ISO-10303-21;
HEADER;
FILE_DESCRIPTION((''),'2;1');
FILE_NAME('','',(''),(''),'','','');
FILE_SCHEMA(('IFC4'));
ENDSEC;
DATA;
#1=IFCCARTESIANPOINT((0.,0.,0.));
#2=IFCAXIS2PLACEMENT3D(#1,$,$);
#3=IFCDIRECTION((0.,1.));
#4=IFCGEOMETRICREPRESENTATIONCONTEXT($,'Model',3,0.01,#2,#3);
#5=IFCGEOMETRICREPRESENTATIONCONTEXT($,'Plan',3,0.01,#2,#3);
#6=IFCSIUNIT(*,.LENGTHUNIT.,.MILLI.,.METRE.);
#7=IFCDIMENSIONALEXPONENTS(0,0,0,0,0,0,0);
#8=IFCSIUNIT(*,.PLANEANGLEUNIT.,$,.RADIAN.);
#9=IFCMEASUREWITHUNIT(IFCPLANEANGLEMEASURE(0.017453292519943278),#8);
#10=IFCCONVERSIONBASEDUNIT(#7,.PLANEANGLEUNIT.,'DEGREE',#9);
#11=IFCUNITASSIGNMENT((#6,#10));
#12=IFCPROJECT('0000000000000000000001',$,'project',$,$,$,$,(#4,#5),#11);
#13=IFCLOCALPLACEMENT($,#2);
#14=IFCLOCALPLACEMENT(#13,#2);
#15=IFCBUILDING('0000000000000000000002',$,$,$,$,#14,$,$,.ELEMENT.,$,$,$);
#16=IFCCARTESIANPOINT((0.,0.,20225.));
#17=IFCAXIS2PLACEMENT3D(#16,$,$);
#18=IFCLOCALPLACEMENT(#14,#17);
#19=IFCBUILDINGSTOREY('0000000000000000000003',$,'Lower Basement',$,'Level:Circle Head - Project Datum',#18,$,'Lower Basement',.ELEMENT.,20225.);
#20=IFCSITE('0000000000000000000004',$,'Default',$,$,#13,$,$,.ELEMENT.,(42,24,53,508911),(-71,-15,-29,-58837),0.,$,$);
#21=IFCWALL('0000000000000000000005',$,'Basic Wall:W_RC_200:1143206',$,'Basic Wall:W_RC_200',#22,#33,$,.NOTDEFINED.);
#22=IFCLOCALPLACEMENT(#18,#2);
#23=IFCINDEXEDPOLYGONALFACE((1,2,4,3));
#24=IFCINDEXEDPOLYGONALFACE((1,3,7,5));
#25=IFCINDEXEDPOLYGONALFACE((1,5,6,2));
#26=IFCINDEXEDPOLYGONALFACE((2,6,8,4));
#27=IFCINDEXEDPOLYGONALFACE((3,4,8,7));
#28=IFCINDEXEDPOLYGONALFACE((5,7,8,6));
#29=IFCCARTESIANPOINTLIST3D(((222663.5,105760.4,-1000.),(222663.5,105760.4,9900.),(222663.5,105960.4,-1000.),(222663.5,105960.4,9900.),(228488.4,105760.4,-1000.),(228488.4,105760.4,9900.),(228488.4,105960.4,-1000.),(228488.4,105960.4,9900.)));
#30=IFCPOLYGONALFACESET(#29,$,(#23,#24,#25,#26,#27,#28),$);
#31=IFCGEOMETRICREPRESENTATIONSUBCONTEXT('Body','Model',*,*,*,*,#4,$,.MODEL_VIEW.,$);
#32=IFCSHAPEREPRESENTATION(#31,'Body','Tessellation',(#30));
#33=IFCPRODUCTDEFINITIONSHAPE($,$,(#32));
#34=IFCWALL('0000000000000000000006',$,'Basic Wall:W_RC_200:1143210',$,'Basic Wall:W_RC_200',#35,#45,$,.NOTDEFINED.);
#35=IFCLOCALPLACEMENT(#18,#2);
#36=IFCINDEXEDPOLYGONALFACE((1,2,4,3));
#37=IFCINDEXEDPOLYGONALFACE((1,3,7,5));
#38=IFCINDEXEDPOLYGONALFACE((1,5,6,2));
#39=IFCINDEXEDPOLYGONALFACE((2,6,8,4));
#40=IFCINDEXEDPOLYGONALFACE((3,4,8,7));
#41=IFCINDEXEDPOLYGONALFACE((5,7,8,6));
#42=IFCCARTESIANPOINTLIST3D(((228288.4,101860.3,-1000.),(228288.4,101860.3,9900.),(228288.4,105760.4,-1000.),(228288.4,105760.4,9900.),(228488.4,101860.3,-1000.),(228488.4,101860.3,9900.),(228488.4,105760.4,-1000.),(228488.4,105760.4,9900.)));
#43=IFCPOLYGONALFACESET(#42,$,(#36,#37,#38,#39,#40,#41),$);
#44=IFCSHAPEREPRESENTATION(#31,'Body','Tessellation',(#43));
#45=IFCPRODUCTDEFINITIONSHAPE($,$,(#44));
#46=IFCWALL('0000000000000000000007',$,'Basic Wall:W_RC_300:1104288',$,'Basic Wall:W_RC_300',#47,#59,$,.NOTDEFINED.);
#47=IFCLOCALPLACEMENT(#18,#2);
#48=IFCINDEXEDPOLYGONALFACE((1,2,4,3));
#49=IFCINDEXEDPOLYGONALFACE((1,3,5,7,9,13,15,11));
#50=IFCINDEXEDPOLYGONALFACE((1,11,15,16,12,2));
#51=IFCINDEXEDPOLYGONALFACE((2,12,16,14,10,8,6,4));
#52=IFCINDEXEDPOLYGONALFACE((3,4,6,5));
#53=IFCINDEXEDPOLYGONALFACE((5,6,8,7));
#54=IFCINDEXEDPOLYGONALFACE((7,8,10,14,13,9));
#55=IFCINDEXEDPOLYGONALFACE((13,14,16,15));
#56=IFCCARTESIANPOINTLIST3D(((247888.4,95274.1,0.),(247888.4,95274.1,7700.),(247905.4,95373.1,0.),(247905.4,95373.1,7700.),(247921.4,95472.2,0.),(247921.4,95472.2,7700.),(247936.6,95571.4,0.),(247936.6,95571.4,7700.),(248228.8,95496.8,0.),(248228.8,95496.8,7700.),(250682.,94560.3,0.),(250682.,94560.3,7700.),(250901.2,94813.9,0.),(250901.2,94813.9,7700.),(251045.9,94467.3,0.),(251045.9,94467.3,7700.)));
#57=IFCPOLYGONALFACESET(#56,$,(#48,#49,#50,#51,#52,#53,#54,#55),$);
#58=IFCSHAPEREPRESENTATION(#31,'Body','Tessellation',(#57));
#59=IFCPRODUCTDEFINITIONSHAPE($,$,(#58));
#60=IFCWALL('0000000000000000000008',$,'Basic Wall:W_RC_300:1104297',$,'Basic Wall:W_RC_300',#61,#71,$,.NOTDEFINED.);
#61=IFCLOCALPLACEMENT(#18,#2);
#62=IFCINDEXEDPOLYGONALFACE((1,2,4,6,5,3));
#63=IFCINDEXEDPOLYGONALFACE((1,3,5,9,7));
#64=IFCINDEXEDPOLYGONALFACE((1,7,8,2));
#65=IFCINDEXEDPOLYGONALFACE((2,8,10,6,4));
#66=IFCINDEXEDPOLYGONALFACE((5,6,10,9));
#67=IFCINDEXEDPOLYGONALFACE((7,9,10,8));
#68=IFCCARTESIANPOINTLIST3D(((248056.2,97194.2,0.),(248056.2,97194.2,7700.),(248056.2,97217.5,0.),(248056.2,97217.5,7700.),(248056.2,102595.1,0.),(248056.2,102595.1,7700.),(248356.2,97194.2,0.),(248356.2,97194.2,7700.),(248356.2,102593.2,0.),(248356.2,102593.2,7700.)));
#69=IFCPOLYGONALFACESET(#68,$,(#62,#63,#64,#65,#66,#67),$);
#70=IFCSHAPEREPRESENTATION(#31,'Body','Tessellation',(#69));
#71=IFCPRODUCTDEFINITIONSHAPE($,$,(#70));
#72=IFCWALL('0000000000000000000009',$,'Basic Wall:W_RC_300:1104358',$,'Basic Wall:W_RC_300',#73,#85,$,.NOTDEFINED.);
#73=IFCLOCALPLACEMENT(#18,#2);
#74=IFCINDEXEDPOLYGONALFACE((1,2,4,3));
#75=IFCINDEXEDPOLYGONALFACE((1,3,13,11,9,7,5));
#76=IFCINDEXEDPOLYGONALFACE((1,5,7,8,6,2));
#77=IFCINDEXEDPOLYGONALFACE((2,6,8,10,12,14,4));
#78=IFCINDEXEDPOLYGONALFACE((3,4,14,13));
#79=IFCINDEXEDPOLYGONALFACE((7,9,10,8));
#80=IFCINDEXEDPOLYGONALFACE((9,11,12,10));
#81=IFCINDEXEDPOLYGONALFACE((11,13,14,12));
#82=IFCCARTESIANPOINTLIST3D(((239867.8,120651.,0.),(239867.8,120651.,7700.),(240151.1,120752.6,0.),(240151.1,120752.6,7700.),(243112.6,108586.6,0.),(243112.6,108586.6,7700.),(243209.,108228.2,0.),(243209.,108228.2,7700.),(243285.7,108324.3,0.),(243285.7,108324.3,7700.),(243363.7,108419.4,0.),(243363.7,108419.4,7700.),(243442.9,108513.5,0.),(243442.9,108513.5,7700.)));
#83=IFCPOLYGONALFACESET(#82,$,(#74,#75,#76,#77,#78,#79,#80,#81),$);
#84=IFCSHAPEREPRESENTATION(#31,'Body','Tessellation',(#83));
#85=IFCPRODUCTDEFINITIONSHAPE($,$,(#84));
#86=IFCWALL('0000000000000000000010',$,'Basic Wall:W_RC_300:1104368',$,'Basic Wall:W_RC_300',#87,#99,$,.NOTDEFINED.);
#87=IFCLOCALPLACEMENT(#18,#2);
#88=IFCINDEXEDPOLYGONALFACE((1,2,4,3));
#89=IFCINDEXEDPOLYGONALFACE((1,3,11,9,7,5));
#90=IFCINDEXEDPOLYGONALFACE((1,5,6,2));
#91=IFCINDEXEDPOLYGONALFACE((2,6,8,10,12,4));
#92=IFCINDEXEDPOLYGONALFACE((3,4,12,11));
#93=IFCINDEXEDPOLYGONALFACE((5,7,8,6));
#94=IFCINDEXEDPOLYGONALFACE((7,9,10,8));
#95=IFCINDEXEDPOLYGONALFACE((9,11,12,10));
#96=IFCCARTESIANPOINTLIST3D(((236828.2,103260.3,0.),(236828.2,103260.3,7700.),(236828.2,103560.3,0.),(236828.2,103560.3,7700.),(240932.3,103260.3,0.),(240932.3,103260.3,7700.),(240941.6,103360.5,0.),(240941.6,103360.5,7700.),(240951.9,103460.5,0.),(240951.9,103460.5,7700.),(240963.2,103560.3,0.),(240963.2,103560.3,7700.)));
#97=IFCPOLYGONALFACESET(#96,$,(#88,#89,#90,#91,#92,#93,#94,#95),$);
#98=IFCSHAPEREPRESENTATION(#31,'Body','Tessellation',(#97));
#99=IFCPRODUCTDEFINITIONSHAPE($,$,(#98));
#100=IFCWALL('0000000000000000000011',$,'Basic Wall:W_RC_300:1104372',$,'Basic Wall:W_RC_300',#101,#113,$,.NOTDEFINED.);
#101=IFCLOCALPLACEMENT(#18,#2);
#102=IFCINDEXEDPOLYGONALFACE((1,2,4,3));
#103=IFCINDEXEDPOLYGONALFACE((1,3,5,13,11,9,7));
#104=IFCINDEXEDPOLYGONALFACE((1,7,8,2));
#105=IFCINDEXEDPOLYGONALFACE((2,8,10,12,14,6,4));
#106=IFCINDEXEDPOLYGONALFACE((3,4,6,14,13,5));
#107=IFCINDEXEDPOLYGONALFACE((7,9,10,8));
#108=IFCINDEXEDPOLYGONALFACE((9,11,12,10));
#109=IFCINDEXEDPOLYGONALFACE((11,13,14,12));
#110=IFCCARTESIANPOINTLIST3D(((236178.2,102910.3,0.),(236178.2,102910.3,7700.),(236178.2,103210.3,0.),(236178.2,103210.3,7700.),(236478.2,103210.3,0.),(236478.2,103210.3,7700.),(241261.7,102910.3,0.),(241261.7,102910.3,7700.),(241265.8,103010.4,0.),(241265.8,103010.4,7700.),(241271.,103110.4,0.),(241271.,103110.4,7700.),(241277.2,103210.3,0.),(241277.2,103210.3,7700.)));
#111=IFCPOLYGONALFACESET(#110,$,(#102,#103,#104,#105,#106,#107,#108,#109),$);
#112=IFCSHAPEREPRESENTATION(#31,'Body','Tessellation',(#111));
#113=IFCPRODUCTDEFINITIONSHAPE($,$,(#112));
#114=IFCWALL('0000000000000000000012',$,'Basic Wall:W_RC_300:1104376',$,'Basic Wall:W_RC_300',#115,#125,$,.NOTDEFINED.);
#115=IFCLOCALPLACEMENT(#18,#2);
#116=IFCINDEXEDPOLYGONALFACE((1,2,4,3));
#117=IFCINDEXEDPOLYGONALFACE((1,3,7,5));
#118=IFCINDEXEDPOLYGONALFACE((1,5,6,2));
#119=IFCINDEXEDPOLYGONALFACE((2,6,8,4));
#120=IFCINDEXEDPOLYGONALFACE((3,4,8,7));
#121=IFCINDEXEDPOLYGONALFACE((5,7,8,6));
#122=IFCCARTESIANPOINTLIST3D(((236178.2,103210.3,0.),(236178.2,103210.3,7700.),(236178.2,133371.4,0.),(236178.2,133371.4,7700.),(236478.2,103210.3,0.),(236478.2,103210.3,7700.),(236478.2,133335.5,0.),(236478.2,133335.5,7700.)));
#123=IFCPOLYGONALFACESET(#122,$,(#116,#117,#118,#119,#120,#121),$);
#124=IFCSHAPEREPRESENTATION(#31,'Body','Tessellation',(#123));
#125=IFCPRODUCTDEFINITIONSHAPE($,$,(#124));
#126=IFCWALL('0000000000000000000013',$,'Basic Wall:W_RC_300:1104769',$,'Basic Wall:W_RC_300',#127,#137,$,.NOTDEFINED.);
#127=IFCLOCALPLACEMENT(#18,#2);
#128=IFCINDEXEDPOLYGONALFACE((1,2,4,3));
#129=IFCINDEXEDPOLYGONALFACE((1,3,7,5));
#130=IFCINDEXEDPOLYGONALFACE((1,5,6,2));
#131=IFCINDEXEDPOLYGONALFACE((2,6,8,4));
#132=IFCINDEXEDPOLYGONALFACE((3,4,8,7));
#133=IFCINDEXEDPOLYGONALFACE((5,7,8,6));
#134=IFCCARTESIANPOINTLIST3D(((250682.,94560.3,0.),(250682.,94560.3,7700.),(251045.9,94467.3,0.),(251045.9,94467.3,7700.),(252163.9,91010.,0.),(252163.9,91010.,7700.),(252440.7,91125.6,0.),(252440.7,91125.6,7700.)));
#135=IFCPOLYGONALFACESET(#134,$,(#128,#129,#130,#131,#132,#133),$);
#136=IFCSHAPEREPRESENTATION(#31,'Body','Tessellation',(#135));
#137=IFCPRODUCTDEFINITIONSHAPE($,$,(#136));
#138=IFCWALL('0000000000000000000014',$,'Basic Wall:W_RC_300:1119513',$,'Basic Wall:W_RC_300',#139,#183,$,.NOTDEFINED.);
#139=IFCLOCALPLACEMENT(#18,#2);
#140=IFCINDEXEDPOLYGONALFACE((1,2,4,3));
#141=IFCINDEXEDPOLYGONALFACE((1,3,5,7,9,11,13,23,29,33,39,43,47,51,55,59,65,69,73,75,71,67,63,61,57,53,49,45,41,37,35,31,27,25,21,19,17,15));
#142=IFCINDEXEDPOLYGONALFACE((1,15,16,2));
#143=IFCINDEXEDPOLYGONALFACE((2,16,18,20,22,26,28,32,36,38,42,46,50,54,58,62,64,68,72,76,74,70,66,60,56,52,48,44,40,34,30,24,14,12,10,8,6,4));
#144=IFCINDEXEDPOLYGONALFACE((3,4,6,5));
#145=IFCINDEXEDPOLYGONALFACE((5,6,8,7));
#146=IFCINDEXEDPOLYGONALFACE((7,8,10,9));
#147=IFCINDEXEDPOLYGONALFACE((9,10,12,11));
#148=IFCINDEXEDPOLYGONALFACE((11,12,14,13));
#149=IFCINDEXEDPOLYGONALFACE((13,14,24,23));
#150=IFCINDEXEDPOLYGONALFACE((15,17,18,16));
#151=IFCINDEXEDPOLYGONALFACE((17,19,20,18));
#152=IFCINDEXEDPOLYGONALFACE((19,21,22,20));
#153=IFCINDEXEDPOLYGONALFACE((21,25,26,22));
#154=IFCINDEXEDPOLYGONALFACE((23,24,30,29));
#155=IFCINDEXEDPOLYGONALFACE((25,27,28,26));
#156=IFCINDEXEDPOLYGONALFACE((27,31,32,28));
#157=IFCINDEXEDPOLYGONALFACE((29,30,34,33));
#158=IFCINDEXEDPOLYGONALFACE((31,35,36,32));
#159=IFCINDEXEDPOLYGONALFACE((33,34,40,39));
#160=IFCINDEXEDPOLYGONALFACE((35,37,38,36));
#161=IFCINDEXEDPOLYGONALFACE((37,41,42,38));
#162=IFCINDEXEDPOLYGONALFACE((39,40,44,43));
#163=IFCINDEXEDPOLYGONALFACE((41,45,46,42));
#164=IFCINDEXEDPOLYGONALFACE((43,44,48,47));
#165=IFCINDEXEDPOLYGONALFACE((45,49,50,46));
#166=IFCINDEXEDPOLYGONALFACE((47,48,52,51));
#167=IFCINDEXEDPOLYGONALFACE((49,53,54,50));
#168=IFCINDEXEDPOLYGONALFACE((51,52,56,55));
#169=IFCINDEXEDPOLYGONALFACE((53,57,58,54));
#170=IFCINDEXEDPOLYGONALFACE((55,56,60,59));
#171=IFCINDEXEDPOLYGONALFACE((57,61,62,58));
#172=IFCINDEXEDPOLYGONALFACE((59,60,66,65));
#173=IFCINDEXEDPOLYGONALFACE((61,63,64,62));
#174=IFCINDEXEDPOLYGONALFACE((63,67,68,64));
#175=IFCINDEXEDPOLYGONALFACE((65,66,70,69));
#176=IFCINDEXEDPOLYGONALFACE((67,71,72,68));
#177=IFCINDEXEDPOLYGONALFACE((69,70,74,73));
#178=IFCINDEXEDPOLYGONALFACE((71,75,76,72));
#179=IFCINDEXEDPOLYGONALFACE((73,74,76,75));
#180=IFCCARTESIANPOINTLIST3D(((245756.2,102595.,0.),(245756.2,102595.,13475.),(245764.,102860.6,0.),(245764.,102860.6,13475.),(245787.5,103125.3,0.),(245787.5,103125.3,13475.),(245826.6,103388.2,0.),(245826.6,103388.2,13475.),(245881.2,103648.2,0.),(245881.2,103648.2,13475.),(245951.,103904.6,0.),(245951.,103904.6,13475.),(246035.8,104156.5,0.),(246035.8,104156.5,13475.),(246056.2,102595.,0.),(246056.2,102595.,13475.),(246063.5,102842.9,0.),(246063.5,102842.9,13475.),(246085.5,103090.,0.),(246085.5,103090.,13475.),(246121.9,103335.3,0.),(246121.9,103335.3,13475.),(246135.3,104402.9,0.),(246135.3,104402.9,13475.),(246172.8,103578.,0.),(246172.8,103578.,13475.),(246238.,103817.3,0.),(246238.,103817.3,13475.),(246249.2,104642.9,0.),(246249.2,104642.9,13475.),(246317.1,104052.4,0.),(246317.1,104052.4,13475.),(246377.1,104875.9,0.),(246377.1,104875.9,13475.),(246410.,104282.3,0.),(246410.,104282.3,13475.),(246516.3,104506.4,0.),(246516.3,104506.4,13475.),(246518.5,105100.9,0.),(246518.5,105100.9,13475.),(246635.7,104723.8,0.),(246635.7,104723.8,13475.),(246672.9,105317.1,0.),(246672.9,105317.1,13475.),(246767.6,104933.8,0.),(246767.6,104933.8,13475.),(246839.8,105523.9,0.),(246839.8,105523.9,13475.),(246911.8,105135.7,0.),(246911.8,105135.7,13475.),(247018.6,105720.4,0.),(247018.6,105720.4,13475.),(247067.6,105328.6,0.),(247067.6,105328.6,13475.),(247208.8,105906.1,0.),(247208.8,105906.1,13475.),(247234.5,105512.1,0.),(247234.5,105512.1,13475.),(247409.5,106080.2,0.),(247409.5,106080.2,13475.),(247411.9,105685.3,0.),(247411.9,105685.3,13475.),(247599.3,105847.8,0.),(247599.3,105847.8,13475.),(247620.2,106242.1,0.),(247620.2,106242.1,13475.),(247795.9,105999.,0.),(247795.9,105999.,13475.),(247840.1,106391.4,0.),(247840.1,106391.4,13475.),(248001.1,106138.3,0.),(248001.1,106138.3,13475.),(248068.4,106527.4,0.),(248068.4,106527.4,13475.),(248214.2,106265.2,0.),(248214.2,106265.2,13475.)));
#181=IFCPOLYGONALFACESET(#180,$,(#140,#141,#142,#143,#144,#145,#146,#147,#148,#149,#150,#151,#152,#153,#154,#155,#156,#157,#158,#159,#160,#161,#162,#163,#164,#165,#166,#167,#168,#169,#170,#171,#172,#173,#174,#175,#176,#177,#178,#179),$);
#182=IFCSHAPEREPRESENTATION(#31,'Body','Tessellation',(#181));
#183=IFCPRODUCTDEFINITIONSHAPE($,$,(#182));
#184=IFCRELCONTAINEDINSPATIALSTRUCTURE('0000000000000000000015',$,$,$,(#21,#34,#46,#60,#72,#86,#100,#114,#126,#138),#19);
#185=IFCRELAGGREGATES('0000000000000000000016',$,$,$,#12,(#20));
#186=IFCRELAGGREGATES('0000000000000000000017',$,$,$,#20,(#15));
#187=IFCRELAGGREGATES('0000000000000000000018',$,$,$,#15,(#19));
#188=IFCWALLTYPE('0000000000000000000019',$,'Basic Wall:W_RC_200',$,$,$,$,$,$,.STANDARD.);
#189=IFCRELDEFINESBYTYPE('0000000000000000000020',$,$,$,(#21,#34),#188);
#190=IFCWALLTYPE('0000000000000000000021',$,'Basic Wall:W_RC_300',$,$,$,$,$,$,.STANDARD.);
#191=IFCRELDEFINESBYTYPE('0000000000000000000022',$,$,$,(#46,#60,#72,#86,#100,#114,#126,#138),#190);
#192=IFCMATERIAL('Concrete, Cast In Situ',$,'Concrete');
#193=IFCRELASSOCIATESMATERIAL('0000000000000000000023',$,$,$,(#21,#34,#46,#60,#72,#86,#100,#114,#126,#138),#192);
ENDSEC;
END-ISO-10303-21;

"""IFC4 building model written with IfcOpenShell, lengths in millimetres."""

from ifc_helpers import new_model, entity, si_unit, converted_unit, direction, frame, origin, place, context, subcontext, project, spatial, line, arc, indexed_curve, outline, extrude, material, type_object, element, save


model = new_model("IFC4")

# Units and contexts
model_context = context("Model", 3, precision=0.01, world=origin(), true_north=direction((0.0, 1.0)))
plan_context = context("Plan", 3, precision=0.01, world=origin(), true_north=direction((0.0, 1.0)))
body_context = subcontext(model_context, "Body", "Model", "MODEL_VIEW")
ifc_project = project(units=[si_unit("LENGTHUNIT", "METRE", prefix="MILLI"), converted_unit("PLANEANGLEUNIT", "DEGREE", entity("IfcPlaneAngleMeasure", 0.017453292519943278), si_unit("PLANEANGLEUNIT", "RADIAN"), dimensions=[0, 0, 0, 0, 0, 0, 0])], contexts=[model_context, plan_context])

# Site, building, storey
site_placement = place(None, origin())
site = spatial("IfcSite", under=ifc_project, at=site_placement, Name="Default", CompositionType="ELEMENT", RefLatitude=(42, 24, 53, 508911), RefLongitude=(-71, -15, -29, -58837), RefElevation=0.0)
building_placement = place(site_placement, origin())
building = spatial("IfcBuilding", under=site, at=building_placement, CompositionType="ELEMENT")
storey_placement = place(building_placement, frame((0.0, 0.0, 20225.0)))
storey = spatial("IfcBuildingStorey", under=building, at=storey_placement, Name="Lower Basement", ObjectType="Level:Circle Head - Project Datum", LongName="Lower Basement", CompositionType="ELEMENT", Elevation=20225.0)

# Walls
ifc_material_1 = material(Name="Concrete, Cast In Situ", Category="Concrete")
wall_type_1 = type_object("IfcWallType", Name="Basic Wall:W_RC_200", PredefinedType="STANDARD")
wall_1_placement = place(storey_placement, frame((228488.4, 105860.4, -1000.0), z_axis=(0.0, 0.0, 1.0), x_axis=(-1.0, 0.0, 0.0)))
element("IfcWall", 1, at=wall_1_placement, inside=storey, type_object=wall_type_1, material=ifc_material_1, Name="Basic Wall:W_RC_200:1143206", ObjectType="Basic Wall:W_RC_200", PredefinedType="NOTDEFINED", context=body_context, shape_type="SweptSolid", body=[
    extrude(outline(indexed_curve([(5824.9, 100.0), (0.0, 100.0), (0.0, -100.0), (5824.9, -100.0), (5824.9, 100.0)], self_intersect=False)), origin(), (0.0, 0.0, 1.0), 10900.0),
])
wall_2_placement = place(storey_placement, frame((228388.4, 101860.3, -1000.0), z_axis=(0.0, 0.0, 1.0), x_axis=(0.0, 1.0, 0.0)))
element("IfcWall", 2, at=wall_2_placement, inside=storey, type_object=wall_type_1, material=ifc_material_1, Name="Basic Wall:W_RC_200:1143210", ObjectType="Basic Wall:W_RC_200", PredefinedType="NOTDEFINED", context=body_context, shape_type="SweptSolid", body=[
    extrude(outline(indexed_curve([(3900.0, 100.0), (0.0, 100.0), (0.0, -100.0), (3900.0, -100.0), (3900.0, 100.0)], self_intersect=False)), origin(), (0.0, 0.0, 1.0), 10900.0),
])
wall_type_2 = type_object("IfcWallType", Name="Basic Wall:W_RC_300", PredefinedType="STANDARD")
wall_3_placement = place(storey_placement, frame((247899.5, 95426.1, 0.0), z_axis=(0.0, 0.0, 1.0), x_axis=(0.968868, -0.247576, 0.0)))
element("IfcWall", 3, at=wall_3_placement, inside=storey, type_object=wall_type_2, material=ifc_material_1, Name="Basic Wall:W_RC_300:1104288", ObjectType="Basic Wall:W_RC_300", PredefinedType="NOTDEFINED", context=body_context, shape_type="SweptSolid", body=[
    extrude(outline(indexed_curve([(3285.8, -150.0), (3059.8, 150.0), (301.6, 150.0), (0.0, 150.0), (14.4, 0.1), (26.8, -150.0), (2910.2, -150.0)], segments=[line(1, 2, 3, 4), arc(4, 5, 6), line(6, 7, 1)], self_intersect=False)), origin(), (0.0, 0.0, 1.0), 7700.0),
])
wall_4_placement = place(storey_placement, frame((248206.2, 102595.1, 0.0), z_axis=(0.0, 0.0, 1.0), x_axis=(0.0, -1.0, 0.0)))
element("IfcWall", 4, at=wall_4_placement, inside=storey, type_object=wall_type_2, material=ifc_material_1, Name="Basic Wall:W_RC_300:1104297", ObjectType="Basic Wall:W_RC_300", PredefinedType="NOTDEFINED", context=body_context, shape_type="SweptSolid", body=[
    extrude(outline(indexed_curve([(5400.9, -150.0), (5400.9, 150.0), (1.8, 150.0), (0.0, -150.0), (5377.5, -150.0), (5400.9, -150.0)], self_intersect=False)), origin(), (0.0, 0.0, 1.0), 7700.0),
])
wall_5_placement = place(storey_placement, frame((243353.8, 108267.2, 0.0), z_axis=(0.0, 0.0, 1.0), x_axis=(-0.259729, 0.965681, 0.0)))
element("IfcWall", 5, at=wall_5_placement, inside=storey, type_object=wall_type_2, material=ifc_material_1, Name="Basic Wall:W_RC_300:1104358", ObjectType="Basic Wall:W_RC_300", PredefinedType="NOTDEFINED", context=body_context, shape_type="SweptSolid", body=[
    extrude(outline(indexed_curve([(12888.8, -150.0), (12864.2, 150.0), (371.1, 150.0), (0.0, 150.0), (108.8, 1.1), (214.7, -150.0)], segments=[line(1, 2, 3, 4), arc(4, 5, 6), line(6, 1)], self_intersect=False)), origin(), (0.0, 0.0, 1.0), 7700.0),
])
wall_6_placement = place(storey_placement, frame((240963.2, 103410.3, 0.0), z_axis=(0.0, 0.0, 1.0), x_axis=(-1.0, 0.0, 0.0)))
element("IfcWall", 6, at=wall_6_placement, inside=storey, type_object=wall_type_2, material=ifc_material_1, Name="Basic Wall:W_RC_300:1104368", ObjectType="Basic Wall:W_RC_300", PredefinedType="NOTDEFINED", context=body_context, shape_type="SweptSolid", body=[
    extrude(outline(indexed_curve([(4135.0, -150.0), (4135.0, 150.0), (30.9, 150.0), (16.6, -0.1), (0.0, -150.0)], segments=[line(1, 2, 3), arc(3, 4, 5), line(5, 1)], self_intersect=False)), origin(), (0.0, 0.0, 1.0), 7700.0),
])
wall_7_placement = place(storey_placement, frame((241277.2, 103060.3, 0.0), z_axis=(0.0, 0.0, 1.0), x_axis=(-1.0, 0.0, 0.0)))
element("IfcWall", 7, at=wall_7_placement, inside=storey, type_object=wall_type_2, material=ifc_material_1, Name="Basic Wall:W_RC_300:1104372", ObjectType="Basic Wall:W_RC_300", PredefinedType="NOTDEFINED", context=body_context, shape_type="SweptSolid", body=[
    extrude(outline(indexed_curve([(5099.1, -150.0), (5099.1, 150.0), (15.5, 150.0), (9.0, -0.1), (0.0, -150.0), (4799.1, -150.0)], segments=[line(1, 2, 3), arc(3, 4, 5), line(5, 6, 1)], self_intersect=False)), origin(), (0.0, 0.0, 1.0), 7700.0),
])
wall_8_placement = place(storey_placement, frame((236328.2, 103210.3, 0.0), z_axis=(0.0, 0.0, 1.0), x_axis=(0.0, 1.0, 0.0)))
element("IfcWall", 8, at=wall_8_placement, inside=storey, type_object=wall_type_2, material=ifc_material_1, Name="Basic Wall:W_RC_300:1104376", ObjectType="Basic Wall:W_RC_300", PredefinedType="NOTDEFINED", context=body_context, shape_type="SweptSolid", body=[
    extrude(outline(indexed_curve([(30125.1, -150.0), (30161.1, 150.0), (0.0, 150.0), (0.0, -150.0), (30125.1, -150.0)], self_intersect=False)), origin(), (0.0, 0.0, 1.0), 7700.0),
])
wall_9_placement = place(storey_placement, frame((250820.4, 94618.0, 0.0), z_axis=(0.0, 0.0, 1.0), x_axis=(0.385203, -0.922832, 0.0)))
element("IfcWall", 9, at=wall_9_placement, inside=storey, type_object=wall_type_2, material=ifc_material_1, Name="Basic Wall:W_RC_300:1104769", ObjectType="Basic Wall:W_RC_300", PredefinedType="NOTDEFINED", context=body_context, shape_type="SweptSolid", body=[
    extrude(outline(indexed_curve([(3847.1, -150.0), (3847.1, 150.0), (226.0, 150.0), (0.0, -150.0), (3847.1, -150.0)], self_intersect=False)), origin(), (0.0, 0.0, 1.0), 7700.0),
])
wall_10_placement = place(storey_placement, frame((245906.2, 102595.0, 0.0)))
element("IfcWall", 10, at=wall_10_placement, inside=storey, type_object=wall_type_2, material=ifc_material_1, Name="Basic Wall:W_RC_300:1119513", ObjectType="Basic Wall:W_RC_300", PredefinedType="NOTDEFINED", context=body_context, shape_type="SweptSolid", body=[
    extrude(outline(indexed_curve([(2162.2, 3932.4), (470.9, 2280.9), (-150.0, 0.0), (150.0, 0.0), (729.5, 2128.8), (2308.0, 3670.2)], segments=[arc(1, 2, 3), line(3, 4), arc(4, 5, 6), line(6, 1)], self_intersect=False)), origin(), (0.0, 0.0, 1.0), 13475.0),
])

save(model, "model.ifc")
